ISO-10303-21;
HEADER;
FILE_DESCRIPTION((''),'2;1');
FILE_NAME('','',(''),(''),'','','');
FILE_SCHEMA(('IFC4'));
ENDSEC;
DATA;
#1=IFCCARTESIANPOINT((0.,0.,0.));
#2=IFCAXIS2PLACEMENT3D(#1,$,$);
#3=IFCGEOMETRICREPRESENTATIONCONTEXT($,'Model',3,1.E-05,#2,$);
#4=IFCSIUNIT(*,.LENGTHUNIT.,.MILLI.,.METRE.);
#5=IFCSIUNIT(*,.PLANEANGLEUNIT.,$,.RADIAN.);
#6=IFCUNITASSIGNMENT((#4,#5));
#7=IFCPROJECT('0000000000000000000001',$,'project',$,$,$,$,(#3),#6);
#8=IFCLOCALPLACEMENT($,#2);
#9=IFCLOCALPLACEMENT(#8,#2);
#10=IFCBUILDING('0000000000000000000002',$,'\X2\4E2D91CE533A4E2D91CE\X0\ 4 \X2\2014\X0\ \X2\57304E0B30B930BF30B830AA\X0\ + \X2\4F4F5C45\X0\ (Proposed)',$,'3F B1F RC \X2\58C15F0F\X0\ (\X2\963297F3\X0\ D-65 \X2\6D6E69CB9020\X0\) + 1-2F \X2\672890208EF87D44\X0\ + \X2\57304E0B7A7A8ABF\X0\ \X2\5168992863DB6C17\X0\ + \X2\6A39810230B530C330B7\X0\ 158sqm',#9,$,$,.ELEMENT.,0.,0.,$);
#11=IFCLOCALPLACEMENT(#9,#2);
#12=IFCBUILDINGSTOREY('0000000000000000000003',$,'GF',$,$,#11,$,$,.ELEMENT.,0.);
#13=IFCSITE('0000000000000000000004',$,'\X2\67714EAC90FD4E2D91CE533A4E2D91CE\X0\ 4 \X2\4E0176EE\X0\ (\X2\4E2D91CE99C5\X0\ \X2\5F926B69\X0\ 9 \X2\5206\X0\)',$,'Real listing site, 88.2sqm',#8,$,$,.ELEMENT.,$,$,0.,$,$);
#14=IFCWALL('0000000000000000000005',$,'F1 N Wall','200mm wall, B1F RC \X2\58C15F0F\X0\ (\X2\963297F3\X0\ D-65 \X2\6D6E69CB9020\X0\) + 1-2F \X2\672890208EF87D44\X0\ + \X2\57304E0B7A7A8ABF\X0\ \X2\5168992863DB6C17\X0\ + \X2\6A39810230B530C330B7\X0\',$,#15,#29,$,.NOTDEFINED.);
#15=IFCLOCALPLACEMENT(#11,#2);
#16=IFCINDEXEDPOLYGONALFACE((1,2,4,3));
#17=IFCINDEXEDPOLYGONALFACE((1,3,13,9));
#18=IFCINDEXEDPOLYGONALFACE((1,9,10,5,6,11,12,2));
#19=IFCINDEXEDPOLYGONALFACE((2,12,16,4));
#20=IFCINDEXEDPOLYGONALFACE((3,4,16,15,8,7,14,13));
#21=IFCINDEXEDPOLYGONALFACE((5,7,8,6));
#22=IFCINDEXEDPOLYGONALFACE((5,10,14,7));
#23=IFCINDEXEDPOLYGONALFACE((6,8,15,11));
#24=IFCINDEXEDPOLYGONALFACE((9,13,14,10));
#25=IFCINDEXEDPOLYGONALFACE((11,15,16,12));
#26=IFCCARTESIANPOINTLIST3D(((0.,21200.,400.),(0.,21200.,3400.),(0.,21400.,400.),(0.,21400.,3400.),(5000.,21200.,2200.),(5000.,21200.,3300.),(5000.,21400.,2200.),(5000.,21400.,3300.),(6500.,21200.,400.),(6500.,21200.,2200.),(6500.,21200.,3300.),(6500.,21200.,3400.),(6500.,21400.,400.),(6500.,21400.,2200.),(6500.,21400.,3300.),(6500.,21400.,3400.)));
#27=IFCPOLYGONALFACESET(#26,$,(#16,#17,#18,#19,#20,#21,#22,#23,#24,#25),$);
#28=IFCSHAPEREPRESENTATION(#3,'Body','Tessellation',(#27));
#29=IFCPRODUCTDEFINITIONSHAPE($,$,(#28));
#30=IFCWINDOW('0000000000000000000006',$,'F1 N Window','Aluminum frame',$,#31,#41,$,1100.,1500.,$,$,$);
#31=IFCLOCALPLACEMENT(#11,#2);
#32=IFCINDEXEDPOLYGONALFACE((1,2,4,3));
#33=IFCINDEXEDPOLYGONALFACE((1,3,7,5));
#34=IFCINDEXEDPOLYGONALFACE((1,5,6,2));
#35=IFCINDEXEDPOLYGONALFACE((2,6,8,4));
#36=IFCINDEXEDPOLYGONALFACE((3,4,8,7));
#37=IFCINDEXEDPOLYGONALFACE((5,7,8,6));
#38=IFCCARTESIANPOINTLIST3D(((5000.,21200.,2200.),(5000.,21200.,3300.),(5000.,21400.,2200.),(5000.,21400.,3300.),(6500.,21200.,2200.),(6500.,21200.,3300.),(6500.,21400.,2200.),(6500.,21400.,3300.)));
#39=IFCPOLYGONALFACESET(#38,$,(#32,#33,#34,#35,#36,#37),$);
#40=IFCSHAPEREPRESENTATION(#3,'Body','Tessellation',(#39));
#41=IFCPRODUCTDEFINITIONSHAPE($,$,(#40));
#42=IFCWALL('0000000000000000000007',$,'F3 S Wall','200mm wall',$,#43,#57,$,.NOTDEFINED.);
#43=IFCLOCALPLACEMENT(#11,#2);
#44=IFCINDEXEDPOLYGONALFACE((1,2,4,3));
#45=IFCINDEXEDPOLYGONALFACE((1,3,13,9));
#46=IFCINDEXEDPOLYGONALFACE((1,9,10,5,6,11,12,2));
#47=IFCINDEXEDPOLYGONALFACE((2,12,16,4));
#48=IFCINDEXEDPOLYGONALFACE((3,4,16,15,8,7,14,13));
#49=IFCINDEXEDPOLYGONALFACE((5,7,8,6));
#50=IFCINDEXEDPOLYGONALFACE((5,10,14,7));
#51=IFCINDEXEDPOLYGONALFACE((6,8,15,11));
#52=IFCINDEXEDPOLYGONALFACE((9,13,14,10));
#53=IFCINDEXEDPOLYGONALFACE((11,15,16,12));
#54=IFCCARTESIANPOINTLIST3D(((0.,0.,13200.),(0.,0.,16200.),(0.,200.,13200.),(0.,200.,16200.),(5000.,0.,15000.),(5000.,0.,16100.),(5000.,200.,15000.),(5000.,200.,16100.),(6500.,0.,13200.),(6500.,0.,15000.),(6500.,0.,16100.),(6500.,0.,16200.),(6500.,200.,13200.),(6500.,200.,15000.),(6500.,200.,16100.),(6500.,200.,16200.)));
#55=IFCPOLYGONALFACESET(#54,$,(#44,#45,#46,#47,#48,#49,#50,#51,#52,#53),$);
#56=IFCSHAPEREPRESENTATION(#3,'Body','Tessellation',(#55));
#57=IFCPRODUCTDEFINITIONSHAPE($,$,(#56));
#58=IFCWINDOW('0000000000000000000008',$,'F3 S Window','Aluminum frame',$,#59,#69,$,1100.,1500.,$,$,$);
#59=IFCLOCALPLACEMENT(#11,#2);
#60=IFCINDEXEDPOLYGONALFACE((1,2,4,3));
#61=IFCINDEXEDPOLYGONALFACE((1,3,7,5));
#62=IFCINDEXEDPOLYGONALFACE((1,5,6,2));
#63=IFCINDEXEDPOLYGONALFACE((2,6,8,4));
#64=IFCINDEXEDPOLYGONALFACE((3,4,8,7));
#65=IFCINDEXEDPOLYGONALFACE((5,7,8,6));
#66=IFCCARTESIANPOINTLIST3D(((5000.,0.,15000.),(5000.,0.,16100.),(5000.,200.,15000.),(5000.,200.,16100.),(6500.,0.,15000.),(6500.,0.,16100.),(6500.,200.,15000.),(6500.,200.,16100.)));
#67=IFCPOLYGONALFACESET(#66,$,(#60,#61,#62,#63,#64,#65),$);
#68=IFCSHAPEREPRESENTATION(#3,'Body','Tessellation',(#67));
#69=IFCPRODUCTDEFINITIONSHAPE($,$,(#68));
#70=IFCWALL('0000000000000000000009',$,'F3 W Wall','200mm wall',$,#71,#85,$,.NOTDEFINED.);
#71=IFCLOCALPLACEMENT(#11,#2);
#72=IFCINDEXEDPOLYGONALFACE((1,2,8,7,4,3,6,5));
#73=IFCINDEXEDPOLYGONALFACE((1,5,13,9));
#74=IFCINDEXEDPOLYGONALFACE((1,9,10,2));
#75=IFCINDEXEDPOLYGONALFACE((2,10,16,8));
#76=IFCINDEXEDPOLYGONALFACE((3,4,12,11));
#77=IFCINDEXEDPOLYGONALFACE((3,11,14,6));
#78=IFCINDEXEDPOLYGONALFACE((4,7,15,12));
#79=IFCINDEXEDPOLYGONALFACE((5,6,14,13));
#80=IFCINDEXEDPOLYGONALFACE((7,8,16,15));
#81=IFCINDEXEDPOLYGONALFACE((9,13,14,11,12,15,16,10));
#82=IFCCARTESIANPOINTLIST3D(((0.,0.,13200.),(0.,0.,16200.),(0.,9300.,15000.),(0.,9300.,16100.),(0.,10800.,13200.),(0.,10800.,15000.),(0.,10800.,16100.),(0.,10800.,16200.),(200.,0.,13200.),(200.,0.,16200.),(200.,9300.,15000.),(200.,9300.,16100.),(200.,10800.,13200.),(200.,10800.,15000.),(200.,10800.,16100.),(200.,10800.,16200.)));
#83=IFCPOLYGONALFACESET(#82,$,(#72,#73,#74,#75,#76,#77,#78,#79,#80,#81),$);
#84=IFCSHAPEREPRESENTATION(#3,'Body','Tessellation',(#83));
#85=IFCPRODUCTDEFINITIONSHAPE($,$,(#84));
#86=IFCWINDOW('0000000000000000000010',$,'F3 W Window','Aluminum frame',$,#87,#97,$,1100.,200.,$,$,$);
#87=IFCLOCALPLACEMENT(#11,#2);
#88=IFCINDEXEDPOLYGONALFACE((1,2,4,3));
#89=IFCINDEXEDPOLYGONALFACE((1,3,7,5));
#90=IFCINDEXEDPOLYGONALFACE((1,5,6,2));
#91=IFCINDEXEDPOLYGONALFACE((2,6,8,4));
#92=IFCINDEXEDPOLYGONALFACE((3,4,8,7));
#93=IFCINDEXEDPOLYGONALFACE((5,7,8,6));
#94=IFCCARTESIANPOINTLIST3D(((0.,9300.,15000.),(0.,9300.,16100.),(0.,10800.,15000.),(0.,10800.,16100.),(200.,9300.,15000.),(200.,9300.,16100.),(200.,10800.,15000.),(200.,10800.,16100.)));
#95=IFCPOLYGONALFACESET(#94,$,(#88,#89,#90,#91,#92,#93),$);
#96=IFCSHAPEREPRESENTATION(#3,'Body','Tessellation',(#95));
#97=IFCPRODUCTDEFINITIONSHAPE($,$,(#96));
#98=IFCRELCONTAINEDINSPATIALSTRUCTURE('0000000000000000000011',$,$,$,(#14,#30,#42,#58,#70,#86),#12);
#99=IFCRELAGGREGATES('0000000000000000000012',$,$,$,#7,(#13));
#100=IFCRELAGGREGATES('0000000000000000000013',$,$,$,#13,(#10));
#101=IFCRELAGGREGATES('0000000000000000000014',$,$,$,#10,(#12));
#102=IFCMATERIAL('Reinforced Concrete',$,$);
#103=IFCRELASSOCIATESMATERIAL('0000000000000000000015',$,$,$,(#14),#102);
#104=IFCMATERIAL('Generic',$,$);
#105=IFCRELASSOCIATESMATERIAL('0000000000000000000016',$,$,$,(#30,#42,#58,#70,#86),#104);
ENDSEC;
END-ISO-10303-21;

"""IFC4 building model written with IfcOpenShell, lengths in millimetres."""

from ifc_helpers import new_model, si_unit, frame, frame_2d, origin, place, context, project, spatial, rectangle, extrude, material, element, fill, save


model = new_model("IFC4")

# Units and contexts
model_context = context("Model", 3, precision=1e-05, world=origin())
ifc_project = project(units=[si_unit("LENGTHUNIT", "METRE", prefix="MILLI"), si_unit("PLANEANGLEUNIT", "RADIAN")], contexts=[model_context])

# Site, building, storey
site_placement = place(None, origin())
site = spatial("IfcSite", under=ifc_project, at=site_placement, Name="東京都中野区中野 4 丁目 (中野駅 徒歩 9 分)", ObjectType="Real listing site, 88.2sqm", CompositionType="ELEMENT", RefElevation=0.0)
building_placement = place(site_placement, origin())
building = spatial("IfcBuilding", under=site, at=building_placement, Name="中野区中野 4 — 地下スタジオ + 住居 (Proposed)", ObjectType="3F B1F RC 壁式 (防音 D-65 浮構造) + 1-2F 木造軸組 + 地下空調 全館換気 + 樹脂サッシ 158sqm", CompositionType="ELEMENT", ElevationOfRefHeight=0.0, ElevationOfTerrain=0.0)
storey_placement = place(building_placement, origin())
storey = spatial("IfcBuildingStorey", under=building, at=storey_placement, Name="GF", CompositionType="ELEMENT", Elevation=0.0)

# Shared definitions
ifc_material_1 = material(Name="Reinforced Concrete")

# Walls, openings, windows
wall_1_placement = place(storey_placement, frame((0.0, 10600.0, 200.0)))
wall_1 = element("IfcWall", 1, at=wall_1_placement, inside=storey, material=ifc_material_1, Name="F1 N Wall", Description="200mm wall, B1F RC 壁式 (防音 D-65 浮構造) + 1-2F 木造軸組 + 地下空調 全館換気 + 樹脂サッシ", PredefinedType="NOTDEFINED", context=model_context, shape_type="SweptSolid", body=[
    extrude(rectangle(XDim=6500.0, YDim=200.0, at=frame_2d((3250.0, 100.0))), frame((0.0, 10600.0, 200.0)), (0.0, 0.0, 1.0), 3000.0),
])
opening_1_placement = place(storey_placement, frame((2500.0, 10600.0, 1100.0)))
opening_1 = element("IfcOpeningElement", 2, at=opening_1_placement, cuts=wall_1, PredefinedType="NOTDEFINED", context=model_context, shape_type="SweptSolid", body=[
    extrude(rectangle(XDim=1500.0, YDim=200.0, at=frame_2d((750.0, 100.0))), frame((2500.0, 10600.0, 1100.0)), (0.0, 0.0, 1.0), 1100.0),
])
ifc_material_2 = material(Name="Generic")
window_1_placement = place(storey_placement, frame((2500.0, 10600.0, 1100.0)))
window_1 = element("IfcWindow", 3, at=window_1_placement, inside=storey, material=ifc_material_2, Name="F1 N Window", Description="Aluminum frame", OverallHeight=1100.0, OverallWidth=1500.0, context=model_context, shape_type="SweptSolid", body=[
    extrude(rectangle(XDim=1500.0, YDim=200.0, at=frame_2d((750.0, 100.0))), frame((2500.0, 10600.0, 1100.0)), (0.0, 0.0, 1.0), 1100.0),
])
fill(opening_1, window_1)
wall_2_placement = place(storey_placement, frame((0.0, 0.0, 6600.0)))
wall_2 = element("IfcWall", 4, at=wall_2_placement, inside=storey, material=ifc_material_2, Name="F3 S Wall", Description="200mm wall", PredefinedType="NOTDEFINED", context=model_context, shape_type="SweptSolid", body=[
    extrude(rectangle(XDim=6500.0, YDim=200.0, at=frame_2d((3250.0, 100.0))), frame((0.0, 0.0, 6600.0)), (0.0, 0.0, 1.0), 3000.0),
])
opening_2_placement = place(storey_placement, frame((2500.0, 0.0, 7500.0)))
opening_2 = element("IfcOpeningElement", 5, at=opening_2_placement, cuts=wall_2, PredefinedType="NOTDEFINED", context=model_context, shape_type="SweptSolid", body=[
    extrude(rectangle(XDim=1500.0, YDim=200.0, at=frame_2d((750.0, 100.0))), frame((2500.0, 0.0, 7500.0)), (0.0, 0.0, 1.0), 1100.0),
])
window_2_placement = place(storey_placement, frame((2500.0, 0.0, 7500.0)))
window_2 = element("IfcWindow", 6, at=window_2_placement, inside=storey, material=ifc_material_2, Name="F3 S Window", Description="Aluminum frame", OverallHeight=1100.0, OverallWidth=1500.0, context=model_context, shape_type="SweptSolid", body=[
    extrude(rectangle(XDim=1500.0, YDim=200.0, at=frame_2d((750.0, 100.0))), frame((2500.0, 0.0, 7500.0)), (0.0, 0.0, 1.0), 1100.0),
])
fill(opening_2, window_2)
wall_3_placement = place(storey_placement, frame((0.0, 0.0, 6600.0)))
wall_3 = element("IfcWall", 7, at=wall_3_placement, inside=storey, material=ifc_material_2, Name="F3 W Wall", Description="200mm wall", PredefinedType="NOTDEFINED", context=model_context, shape_type="SweptSolid", body=[
    extrude(rectangle(XDim=200.0, YDim=10800.0, at=frame_2d((100.0, 5400.0))), frame((0.0, 0.0, 6600.0)), (0.0, 0.0, 1.0), 3000.0),
])
opening_3_placement = place(storey_placement, frame((0.0, 4650.0, 7500.0)))
opening_3 = element("IfcOpeningElement", 8, at=opening_3_placement, cuts=wall_3, PredefinedType="NOTDEFINED", context=model_context, shape_type="SweptSolid", body=[
    extrude(rectangle(XDim=200.0, YDim=1500.0, at=frame_2d((100.0, 750.0))), frame((0.0, 4650.0, 7500.0)), (0.0, 0.0, 1.0), 1100.0),
])
window_3_placement = place(storey_placement, frame((0.0, 4650.0, 7500.0)))
window_3 = element("IfcWindow", 9, at=window_3_placement, inside=storey, material=ifc_material_2, Name="F3 W Window", Description="Aluminum frame", OverallHeight=1100.0, OverallWidth=200.0, context=model_context, shape_type="SweptSolid", body=[
    extrude(rectangle(XDim=200.0, YDim=1500.0, at=frame_2d((100.0, 750.0))), frame((0.0, 4650.0, 7500.0)), (0.0, 0.0, 1.0), 1100.0),
])
fill(opening_3, window_3)

save(model, "model.ifc")
